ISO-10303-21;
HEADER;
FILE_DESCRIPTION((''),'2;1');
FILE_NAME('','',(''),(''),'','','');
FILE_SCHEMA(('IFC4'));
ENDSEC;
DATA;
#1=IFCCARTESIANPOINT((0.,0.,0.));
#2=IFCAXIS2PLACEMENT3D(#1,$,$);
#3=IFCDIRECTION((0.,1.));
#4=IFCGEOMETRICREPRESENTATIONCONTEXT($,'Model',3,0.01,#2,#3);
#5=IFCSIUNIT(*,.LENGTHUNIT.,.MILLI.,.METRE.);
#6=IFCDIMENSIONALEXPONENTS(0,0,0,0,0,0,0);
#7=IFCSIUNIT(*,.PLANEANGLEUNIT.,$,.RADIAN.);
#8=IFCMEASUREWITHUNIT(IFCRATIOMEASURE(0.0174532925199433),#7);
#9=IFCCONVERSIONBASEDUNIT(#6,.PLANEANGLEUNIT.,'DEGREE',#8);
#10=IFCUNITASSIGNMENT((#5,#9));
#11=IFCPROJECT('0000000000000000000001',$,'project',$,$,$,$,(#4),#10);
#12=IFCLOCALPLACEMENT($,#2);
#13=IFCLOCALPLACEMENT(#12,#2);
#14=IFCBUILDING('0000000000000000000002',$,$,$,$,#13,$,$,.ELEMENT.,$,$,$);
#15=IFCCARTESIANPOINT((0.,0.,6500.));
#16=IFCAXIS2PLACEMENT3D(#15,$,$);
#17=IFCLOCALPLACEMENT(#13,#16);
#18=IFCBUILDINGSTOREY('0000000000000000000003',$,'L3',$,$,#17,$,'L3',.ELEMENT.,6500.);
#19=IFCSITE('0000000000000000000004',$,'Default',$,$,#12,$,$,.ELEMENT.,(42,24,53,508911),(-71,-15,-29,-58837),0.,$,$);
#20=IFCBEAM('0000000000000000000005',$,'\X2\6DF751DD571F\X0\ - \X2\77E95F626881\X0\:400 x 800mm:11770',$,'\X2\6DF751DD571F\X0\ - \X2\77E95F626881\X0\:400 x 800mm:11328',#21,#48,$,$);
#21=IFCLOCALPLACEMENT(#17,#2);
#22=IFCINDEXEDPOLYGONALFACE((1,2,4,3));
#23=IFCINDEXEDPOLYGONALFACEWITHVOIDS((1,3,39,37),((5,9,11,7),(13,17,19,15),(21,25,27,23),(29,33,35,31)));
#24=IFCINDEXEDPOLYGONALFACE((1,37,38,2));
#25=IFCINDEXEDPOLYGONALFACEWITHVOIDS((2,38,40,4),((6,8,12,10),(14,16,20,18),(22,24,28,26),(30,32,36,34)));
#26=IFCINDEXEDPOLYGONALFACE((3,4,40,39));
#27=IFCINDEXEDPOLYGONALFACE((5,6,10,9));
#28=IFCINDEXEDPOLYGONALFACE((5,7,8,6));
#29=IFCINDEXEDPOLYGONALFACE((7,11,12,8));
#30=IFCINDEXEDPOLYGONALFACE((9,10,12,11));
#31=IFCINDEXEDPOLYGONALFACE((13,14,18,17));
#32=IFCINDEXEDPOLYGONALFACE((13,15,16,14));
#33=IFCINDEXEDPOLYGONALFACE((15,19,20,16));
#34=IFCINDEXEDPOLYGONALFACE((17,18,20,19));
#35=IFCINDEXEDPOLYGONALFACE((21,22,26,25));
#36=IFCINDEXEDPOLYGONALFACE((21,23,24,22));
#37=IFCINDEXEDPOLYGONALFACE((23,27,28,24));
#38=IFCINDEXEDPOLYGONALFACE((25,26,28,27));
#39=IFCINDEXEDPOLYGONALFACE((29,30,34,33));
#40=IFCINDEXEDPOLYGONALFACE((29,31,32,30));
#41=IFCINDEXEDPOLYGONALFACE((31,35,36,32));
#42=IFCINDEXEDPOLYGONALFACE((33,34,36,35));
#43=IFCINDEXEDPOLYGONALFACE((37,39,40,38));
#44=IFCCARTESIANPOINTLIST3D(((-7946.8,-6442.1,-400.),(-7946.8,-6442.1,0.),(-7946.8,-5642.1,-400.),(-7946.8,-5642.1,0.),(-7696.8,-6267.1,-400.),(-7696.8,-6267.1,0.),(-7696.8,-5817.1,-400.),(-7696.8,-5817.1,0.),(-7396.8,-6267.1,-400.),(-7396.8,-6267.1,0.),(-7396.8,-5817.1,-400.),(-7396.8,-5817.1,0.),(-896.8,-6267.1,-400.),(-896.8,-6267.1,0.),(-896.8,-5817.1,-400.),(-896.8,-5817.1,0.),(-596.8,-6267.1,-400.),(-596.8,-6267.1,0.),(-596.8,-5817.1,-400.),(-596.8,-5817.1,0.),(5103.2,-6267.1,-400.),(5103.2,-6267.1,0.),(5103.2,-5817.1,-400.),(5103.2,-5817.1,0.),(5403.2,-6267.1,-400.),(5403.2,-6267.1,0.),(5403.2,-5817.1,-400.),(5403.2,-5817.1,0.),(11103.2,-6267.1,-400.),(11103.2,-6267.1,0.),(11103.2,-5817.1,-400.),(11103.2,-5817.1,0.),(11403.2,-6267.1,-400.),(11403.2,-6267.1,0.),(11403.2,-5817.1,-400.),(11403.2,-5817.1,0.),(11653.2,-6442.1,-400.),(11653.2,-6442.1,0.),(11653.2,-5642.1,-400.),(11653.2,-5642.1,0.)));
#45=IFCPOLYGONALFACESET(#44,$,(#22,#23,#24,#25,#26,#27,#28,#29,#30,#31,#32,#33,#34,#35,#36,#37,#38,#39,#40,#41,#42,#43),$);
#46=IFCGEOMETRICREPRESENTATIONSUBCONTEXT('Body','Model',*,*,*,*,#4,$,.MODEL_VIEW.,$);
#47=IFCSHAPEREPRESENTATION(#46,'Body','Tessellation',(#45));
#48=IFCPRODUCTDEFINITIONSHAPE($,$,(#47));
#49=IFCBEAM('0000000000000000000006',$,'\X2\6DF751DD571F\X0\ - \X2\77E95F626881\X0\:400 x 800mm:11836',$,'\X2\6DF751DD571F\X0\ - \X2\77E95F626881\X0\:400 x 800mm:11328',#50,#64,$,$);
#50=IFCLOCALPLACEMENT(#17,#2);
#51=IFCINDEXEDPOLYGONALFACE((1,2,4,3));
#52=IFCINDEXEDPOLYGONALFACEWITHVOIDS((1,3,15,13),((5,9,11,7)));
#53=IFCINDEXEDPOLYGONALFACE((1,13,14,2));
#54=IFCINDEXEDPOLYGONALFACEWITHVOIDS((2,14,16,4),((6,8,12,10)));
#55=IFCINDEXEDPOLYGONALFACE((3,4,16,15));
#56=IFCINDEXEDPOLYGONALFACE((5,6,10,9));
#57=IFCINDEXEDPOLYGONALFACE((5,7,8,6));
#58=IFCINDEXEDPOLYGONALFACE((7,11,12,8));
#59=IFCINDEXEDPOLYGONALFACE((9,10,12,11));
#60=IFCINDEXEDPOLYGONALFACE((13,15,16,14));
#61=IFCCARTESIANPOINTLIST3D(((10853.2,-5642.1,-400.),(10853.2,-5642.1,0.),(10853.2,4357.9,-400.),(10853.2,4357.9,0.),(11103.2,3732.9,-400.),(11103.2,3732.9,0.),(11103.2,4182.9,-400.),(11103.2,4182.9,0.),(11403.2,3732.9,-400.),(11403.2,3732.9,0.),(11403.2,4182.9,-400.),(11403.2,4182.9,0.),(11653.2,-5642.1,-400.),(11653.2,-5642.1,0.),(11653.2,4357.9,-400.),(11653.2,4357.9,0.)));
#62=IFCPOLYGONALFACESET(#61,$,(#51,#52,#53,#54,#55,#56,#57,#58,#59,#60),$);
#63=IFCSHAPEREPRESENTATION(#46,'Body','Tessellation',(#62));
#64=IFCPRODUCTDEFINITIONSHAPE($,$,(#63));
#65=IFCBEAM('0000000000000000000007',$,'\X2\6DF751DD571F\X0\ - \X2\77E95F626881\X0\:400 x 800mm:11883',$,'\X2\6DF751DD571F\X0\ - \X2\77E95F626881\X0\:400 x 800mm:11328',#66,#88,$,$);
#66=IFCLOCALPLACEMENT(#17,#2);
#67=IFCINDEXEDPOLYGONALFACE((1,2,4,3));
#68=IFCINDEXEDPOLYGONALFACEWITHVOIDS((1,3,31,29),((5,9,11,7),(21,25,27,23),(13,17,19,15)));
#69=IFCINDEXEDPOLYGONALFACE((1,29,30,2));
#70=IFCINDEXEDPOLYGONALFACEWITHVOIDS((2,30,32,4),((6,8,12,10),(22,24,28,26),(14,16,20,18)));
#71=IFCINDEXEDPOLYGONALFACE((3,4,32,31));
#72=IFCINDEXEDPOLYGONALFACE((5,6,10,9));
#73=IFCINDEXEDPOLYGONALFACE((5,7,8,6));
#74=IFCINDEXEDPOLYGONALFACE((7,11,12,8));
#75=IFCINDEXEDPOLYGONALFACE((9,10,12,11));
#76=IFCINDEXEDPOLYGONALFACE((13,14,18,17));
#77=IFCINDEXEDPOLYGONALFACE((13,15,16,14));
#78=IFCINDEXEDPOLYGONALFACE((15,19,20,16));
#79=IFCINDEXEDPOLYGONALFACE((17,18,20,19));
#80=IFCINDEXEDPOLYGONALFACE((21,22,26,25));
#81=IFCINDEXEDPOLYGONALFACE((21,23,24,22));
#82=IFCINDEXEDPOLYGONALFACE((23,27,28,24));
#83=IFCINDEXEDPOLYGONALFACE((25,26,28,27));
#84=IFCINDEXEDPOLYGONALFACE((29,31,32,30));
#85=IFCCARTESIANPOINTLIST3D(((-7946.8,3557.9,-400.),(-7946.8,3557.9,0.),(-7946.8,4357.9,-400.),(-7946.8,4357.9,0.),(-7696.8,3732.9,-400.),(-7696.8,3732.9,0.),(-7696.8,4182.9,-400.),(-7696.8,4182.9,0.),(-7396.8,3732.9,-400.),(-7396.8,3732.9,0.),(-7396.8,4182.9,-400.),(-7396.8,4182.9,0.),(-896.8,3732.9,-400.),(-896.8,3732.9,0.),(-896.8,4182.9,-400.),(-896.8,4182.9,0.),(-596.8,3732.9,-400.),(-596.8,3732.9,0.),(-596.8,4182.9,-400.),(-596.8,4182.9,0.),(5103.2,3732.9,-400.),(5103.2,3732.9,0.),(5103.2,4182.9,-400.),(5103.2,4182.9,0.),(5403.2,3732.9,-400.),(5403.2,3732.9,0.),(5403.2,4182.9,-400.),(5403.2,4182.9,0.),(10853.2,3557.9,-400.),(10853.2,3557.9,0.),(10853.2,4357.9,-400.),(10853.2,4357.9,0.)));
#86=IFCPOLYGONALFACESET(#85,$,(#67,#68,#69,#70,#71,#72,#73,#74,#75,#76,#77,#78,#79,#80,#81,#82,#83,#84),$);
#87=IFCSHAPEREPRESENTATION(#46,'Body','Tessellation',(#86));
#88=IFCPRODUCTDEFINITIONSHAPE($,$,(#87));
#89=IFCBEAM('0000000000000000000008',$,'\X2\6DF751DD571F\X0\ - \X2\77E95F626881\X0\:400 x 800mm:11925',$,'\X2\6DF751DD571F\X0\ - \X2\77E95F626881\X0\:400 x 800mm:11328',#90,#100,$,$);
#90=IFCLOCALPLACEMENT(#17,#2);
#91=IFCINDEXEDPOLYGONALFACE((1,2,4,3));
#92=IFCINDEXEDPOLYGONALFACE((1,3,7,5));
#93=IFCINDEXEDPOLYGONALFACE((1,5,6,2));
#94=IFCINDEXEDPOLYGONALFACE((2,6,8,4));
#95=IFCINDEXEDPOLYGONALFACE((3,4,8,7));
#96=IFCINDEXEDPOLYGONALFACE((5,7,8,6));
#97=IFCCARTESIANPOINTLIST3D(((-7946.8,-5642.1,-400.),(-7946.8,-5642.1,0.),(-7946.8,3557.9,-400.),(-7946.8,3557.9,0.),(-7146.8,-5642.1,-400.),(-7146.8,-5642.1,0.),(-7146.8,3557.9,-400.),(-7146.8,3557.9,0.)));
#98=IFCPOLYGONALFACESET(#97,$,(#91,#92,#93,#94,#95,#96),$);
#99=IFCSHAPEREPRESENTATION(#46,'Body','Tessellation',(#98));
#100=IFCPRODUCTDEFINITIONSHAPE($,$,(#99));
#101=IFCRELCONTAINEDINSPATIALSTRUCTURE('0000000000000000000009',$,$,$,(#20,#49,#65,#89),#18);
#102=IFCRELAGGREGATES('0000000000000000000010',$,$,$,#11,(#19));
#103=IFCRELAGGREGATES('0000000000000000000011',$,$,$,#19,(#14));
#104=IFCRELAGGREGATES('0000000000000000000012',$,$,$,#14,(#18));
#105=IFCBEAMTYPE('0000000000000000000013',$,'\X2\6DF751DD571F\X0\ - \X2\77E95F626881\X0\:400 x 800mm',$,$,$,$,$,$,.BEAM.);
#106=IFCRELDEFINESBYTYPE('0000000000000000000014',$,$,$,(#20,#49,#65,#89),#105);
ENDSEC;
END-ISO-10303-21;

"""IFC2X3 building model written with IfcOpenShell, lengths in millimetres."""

from ifc_helpers import new_model, entity, si_unit, converted_unit, direction, frame, frame_2d, origin, origin_2d_with_axis, place, context, subcontext, project, spatial, rectangle, extrude, boolean, type_object, element, save


model = new_model("IFC2X3")

# Units and contexts
model_context = context("Model", 3, precision=0.01, world=origin(), true_north=direction((0.0, 1.0)))
body_context = subcontext(model_context, "Body", "Model", "MODEL_VIEW")
ifc_project = project(units=[si_unit("LENGTHUNIT", "METRE", prefix="MILLI"), converted_unit("PLANEANGLEUNIT", "DEGREE", entity("IfcRatioMeasure", 0.0174532925199433), si_unit("PLANEANGLEUNIT", "RADIAN"), dimensions=[0, 0, 0, 0, 0, 0, 0])], contexts=[model_context])

# Site, building, storey
site_placement = place(None, origin())
site = spatial("IfcSite", under=ifc_project, at=site_placement, Name="Default", CompositionType="ELEMENT", RefLatitude=(42, 24, 53, 508911), RefLongitude=(-71, -15, -29, -58837), RefElevation=0.0)
building_placement = place(site_placement, origin())
building = spatial("IfcBuilding", under=site, at=building_placement, CompositionType="ELEMENT")
storey_placement = place(building_placement, frame((0.0, 0.0, 6500.0)))
storey = spatial("IfcBuildingStorey", under=building, at=storey_placement, Name="L3", LongName="L3", CompositionType="ELEMENT", Elevation=6500.0)

# Beams
beam_type = type_object("IfcBeamType", Name="混凝土 - 矩形梁:400 x 800mm", PredefinedType="BEAM")
beam_1_placement = place(storey_placement, frame((-7546.8, -6042.1, 0.0)))
element("IfcBeam", 1, at=beam_1_placement, inside=storey, type_object=beam_type, Name="混凝土 - 矩形梁:400 x 800mm:11770", ObjectType="混凝土 - 矩形梁:400 x 800mm:11328", context=body_context, shape_type="CSG", body=[
    boolean("DIFFERENCE", boolean("DIFFERENCE", boolean("DIFFERENCE", boolean("DIFFERENCE", extrude(rectangle(XDim=400.0, YDim=800.0, at=frame_2d((0.0, 0.0), x_axis=(1.0, 0.0))), frame((-400.0, 0.0, -200.0), z_axis=(1.0, 0.0, 0.0), x_axis=(0.0, 0.0, -1.0)), (0.0, 0.0, 1.0), 19600.0), extrude(rectangle(XDim=300.0, YDim=450.0, at=frame_2d((0.0, 0.0), x_axis=(1.0, 0.0))), frame((12800.0, 0.0, -400.0), z_axis=(0.0, 0.0, 1.0), x_axis=(-1.0, 0.0, 0.0)), (0.0, 0.0, 1.0), 400.0)), extrude(rectangle(XDim=300.0, YDim=450.0, at=origin_2d_with_axis()), frame((6800.0, 0.0, -400.0), z_axis=(0.0, 0.0, 1.0), x_axis=(-1.0, 0.0, 0.0)), (0.0, 0.0, 1.0), 400.0)), extrude(rectangle(XDim=300.0, YDim=450.0, at=origin_2d_with_axis()), frame((18800.0, 0.0, -400.0), z_axis=(0.0, 0.0, 1.0), x_axis=(-1.0, 0.0, 0.0)), (0.0, 0.0, 1.0), 400.0)), extrude(rectangle(XDim=300.0, YDim=450.0, at=frame_2d((0.0, 0.0), x_axis=(1.0, 0.0))), frame((0.0, 0.0, -400.0), z_axis=(0.0, 0.0, 1.0), x_axis=(-1.0, 0.0, 0.0)), (0.0, 0.0, 1.0), 400.0)),
])
beam_2_placement = place(storey_placement, frame((11253.2, -6042.1, 0.0), z_axis=(0.0, 0.0, 1.0), x_axis=(0.0, 1.0, 0.0)))
element("IfcBeam", 2, at=beam_2_placement, inside=storey, type_object=beam_type, Name="混凝土 - 矩形梁:400 x 800mm:11836", ObjectType="混凝土 - 矩形梁:400 x 800mm:11328", context=body_context, shape_type="CSG", body=[
    boolean("DIFFERENCE", extrude(rectangle(XDim=400.0, YDim=800.0, at=frame_2d((0.0, 0.0), x_axis=(1.0, 0.0))), frame((400.0, 0.0, -200.0), z_axis=(1.0, 0.0, 0.0), x_axis=(0.0, 0.0, -1.0)), (0.0, 0.0, 1.0), 10000.0), extrude(rectangle(XDim=450.0, YDim=300.0, at=frame_2d((0.0, 0.0), x_axis=(1.0, 0.0))), frame((10000.0, 0.0, 0.0), z_axis=(0.0, 0.0, -1.0), x_axis=(-1.0, 0.0, 0.0)), (0.0, 0.0, 1.0), 400.0)),
])
beam_3_placement = place(storey_placement, frame((11253.2, 3957.9, 0.0), z_axis=(0.0, 0.0, 1.0), x_axis=(-1.0, 0.0, 0.0)))
element("IfcBeam", 3, at=beam_3_placement, inside=storey, type_object=beam_type, Name="混凝土 - 矩形梁:400 x 800mm:11883", ObjectType="混凝土 - 矩形梁:400 x 800mm:11328", context=body_context, shape_type="CSG", body=[
    boolean("DIFFERENCE", boolean("DIFFERENCE", boolean("DIFFERENCE", extrude(rectangle(XDim=400.0, YDim=800.0, at=frame_2d((0.0, 0.0), x_axis=(1.0, 0.0))), frame((400.0, 0.0, -200.0), z_axis=(1.0, 0.0, 0.0), x_axis=(0.0, 0.0, -1.0)), (0.0, 0.0, 1.0), 18800.0), extrude(rectangle(XDim=300.0, YDim=450.0, at=frame_2d((0.0, 0.0), x_axis=(1.0, 0.0))), frame((12000.0, 0.0, -400.0)), (0.0, 0.0, 1.0), 400.0)), extrude(rectangle(XDim=300.0, YDim=450.0, at=origin_2d_with_axis()), frame((6000.0, 0.0, -400.0)), (0.0, 0.0, 1.0), 400.0)), extrude(rectangle(XDim=300.0, YDim=450.0, at=frame_2d((0.0, 0.0), x_axis=(1.0, 0.0))), frame((18800.0, 0.0, -400.0)), (0.0, 0.0, 1.0), 400.0)),
])
beam_4_placement = place(storey_placement, frame((-7546.8, 3957.9, 0.0), z_axis=(0.0, 0.0, 1.0), x_axis=(0.0, -1.0, 0.0)))
element("IfcBeam", 4, at=beam_4_placement, inside=storey, type_object=beam_type, Name="混凝土 - 矩形梁:400 x 800mm:11925", ObjectType="混凝土 - 矩形梁:400 x 800mm:11328", context=body_context, shape_type="SweptSolid", body=[
    extrude(rectangle(XDim=400.0, YDim=800.0, at=frame_2d((0.0, 0.0), x_axis=(1.0, 0.0))), frame((400.0, 0.0, -200.0), z_axis=(1.0, 0.0, 0.0), x_axis=(0.0, 0.0, -1.0)), (0.0, 0.0, 1.0), 9200.0),
])

save(model, "model.ifc")
